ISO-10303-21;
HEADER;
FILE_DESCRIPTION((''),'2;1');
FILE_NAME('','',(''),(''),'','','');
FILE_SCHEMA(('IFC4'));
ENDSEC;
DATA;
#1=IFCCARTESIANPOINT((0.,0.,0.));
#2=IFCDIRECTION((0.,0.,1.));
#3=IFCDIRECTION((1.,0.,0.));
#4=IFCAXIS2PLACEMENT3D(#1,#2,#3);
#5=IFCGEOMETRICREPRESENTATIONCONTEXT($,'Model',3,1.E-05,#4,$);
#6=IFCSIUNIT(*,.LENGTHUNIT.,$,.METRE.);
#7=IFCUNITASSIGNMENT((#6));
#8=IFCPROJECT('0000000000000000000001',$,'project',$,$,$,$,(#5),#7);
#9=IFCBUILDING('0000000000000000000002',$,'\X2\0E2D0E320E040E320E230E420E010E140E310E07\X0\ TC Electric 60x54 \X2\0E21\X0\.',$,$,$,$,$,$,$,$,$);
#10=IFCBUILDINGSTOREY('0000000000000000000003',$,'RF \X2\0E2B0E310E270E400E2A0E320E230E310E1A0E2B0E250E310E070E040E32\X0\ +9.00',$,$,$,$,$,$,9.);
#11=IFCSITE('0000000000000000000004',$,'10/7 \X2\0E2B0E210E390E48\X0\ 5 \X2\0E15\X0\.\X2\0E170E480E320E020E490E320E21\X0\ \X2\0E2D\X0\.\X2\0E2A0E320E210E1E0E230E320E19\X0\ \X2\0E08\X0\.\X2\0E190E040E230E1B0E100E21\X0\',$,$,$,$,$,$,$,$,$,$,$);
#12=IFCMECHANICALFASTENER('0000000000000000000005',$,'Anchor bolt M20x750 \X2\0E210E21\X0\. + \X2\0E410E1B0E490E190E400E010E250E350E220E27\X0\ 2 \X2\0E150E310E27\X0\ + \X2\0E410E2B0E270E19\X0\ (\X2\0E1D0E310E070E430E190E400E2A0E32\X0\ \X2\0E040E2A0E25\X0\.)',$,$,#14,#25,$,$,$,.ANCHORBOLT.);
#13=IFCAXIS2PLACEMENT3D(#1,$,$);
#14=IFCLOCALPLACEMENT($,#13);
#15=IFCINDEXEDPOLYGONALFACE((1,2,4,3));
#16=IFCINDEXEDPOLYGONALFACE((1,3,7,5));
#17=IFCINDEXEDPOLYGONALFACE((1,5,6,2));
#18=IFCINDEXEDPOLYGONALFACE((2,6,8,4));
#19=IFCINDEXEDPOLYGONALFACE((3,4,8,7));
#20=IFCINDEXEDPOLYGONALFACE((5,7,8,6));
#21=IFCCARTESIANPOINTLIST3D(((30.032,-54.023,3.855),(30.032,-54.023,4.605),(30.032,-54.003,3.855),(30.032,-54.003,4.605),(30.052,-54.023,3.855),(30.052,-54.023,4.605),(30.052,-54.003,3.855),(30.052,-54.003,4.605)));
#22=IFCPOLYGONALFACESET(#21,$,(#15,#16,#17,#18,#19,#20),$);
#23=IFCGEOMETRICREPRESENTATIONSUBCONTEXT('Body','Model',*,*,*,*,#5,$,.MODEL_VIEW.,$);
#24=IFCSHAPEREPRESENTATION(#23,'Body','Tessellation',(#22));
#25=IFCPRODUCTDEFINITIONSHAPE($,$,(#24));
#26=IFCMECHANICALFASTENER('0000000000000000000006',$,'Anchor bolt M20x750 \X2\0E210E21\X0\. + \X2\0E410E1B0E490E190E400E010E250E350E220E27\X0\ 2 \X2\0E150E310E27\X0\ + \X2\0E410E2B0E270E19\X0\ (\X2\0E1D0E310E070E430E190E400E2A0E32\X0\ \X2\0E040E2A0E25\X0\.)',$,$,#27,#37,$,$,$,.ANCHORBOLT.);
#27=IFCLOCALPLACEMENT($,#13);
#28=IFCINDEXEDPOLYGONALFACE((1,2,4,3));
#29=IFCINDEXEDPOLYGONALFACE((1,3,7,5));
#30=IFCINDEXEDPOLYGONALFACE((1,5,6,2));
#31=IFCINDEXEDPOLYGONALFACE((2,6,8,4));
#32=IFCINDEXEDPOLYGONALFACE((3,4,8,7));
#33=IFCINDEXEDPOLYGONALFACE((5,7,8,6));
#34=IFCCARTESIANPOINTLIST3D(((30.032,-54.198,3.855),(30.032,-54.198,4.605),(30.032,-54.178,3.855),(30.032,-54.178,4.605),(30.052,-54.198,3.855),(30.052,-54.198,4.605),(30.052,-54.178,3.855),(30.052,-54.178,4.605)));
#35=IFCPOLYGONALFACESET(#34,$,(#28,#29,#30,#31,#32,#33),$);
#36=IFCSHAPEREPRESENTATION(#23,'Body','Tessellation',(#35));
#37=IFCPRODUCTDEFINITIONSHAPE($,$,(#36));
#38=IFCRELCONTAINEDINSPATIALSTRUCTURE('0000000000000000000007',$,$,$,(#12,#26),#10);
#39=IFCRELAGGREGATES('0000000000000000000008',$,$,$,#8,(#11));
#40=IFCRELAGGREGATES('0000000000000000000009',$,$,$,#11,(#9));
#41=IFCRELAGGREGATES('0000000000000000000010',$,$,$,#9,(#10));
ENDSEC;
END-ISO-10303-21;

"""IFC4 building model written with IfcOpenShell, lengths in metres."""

from ifc_helpers import new_model, si_unit, frame, origin, origin_with_axes, origin_2d, place, context, subcontext, project, spatial, rectangle, extrude, element, save


model = new_model("IFC4")

# Units and contexts
model_context = context("Model", 3, precision=1e-05, world=origin_with_axes())
body_context = subcontext(model_context, "Body", "Model", "MODEL_VIEW")
ifc_project = project(units=[si_unit("LENGTHUNIT", "METRE")], contexts=[model_context])

# Site, building, storey
site = spatial("IfcSite", under=ifc_project, Name="10/7 หมู่ 5 ต.ท่าข้าม อ.สามพราน จ.นครปฐม")
building = spatial("IfcBuilding", under=site, Name="อาคารโกดัง TC Electric 60x54 ม.")
storey = spatial("IfcBuildingStorey", under=building, Name="RF หัวเสารับหลังคา +9.00", Elevation=9.0)

# Mechanical fasteners
for number, where, z_axis, x_axis, name in (
    (1, (30.042, -54.013, 3.855), (0.0, 0.0, 1.0), (1.0, 0.0, 0.0), "Anchor bolt M20x750 มม. + แป้นเกลียว 2 ตัว + แหวน (ฝังในเสา คสล.)"),
    (2, (30.042, -54.188, 3.855), (0.0, 0.0, 1.0), (1.0, 0.0, 0.0), "Anchor bolt M20x750 มม. + แป้นเกลียว 2 ตัว + แหวน (ฝังในเสา คสล.)"),
):
    element("IfcMechanicalFastener", number, at=place(None, frame(where, z_axis=z_axis, x_axis=x_axis)), inside=storey, Name=name, PredefinedType="ANCHORBOLT", context=body_context, shape_type="SweptSolid", body=[
        extrude(rectangle(XDim=0.02, YDim=0.02, at=origin_2d()), origin(), (0.0, 0.0, 1.0), 0.75),
    ])

save(model, "model.ifc")
